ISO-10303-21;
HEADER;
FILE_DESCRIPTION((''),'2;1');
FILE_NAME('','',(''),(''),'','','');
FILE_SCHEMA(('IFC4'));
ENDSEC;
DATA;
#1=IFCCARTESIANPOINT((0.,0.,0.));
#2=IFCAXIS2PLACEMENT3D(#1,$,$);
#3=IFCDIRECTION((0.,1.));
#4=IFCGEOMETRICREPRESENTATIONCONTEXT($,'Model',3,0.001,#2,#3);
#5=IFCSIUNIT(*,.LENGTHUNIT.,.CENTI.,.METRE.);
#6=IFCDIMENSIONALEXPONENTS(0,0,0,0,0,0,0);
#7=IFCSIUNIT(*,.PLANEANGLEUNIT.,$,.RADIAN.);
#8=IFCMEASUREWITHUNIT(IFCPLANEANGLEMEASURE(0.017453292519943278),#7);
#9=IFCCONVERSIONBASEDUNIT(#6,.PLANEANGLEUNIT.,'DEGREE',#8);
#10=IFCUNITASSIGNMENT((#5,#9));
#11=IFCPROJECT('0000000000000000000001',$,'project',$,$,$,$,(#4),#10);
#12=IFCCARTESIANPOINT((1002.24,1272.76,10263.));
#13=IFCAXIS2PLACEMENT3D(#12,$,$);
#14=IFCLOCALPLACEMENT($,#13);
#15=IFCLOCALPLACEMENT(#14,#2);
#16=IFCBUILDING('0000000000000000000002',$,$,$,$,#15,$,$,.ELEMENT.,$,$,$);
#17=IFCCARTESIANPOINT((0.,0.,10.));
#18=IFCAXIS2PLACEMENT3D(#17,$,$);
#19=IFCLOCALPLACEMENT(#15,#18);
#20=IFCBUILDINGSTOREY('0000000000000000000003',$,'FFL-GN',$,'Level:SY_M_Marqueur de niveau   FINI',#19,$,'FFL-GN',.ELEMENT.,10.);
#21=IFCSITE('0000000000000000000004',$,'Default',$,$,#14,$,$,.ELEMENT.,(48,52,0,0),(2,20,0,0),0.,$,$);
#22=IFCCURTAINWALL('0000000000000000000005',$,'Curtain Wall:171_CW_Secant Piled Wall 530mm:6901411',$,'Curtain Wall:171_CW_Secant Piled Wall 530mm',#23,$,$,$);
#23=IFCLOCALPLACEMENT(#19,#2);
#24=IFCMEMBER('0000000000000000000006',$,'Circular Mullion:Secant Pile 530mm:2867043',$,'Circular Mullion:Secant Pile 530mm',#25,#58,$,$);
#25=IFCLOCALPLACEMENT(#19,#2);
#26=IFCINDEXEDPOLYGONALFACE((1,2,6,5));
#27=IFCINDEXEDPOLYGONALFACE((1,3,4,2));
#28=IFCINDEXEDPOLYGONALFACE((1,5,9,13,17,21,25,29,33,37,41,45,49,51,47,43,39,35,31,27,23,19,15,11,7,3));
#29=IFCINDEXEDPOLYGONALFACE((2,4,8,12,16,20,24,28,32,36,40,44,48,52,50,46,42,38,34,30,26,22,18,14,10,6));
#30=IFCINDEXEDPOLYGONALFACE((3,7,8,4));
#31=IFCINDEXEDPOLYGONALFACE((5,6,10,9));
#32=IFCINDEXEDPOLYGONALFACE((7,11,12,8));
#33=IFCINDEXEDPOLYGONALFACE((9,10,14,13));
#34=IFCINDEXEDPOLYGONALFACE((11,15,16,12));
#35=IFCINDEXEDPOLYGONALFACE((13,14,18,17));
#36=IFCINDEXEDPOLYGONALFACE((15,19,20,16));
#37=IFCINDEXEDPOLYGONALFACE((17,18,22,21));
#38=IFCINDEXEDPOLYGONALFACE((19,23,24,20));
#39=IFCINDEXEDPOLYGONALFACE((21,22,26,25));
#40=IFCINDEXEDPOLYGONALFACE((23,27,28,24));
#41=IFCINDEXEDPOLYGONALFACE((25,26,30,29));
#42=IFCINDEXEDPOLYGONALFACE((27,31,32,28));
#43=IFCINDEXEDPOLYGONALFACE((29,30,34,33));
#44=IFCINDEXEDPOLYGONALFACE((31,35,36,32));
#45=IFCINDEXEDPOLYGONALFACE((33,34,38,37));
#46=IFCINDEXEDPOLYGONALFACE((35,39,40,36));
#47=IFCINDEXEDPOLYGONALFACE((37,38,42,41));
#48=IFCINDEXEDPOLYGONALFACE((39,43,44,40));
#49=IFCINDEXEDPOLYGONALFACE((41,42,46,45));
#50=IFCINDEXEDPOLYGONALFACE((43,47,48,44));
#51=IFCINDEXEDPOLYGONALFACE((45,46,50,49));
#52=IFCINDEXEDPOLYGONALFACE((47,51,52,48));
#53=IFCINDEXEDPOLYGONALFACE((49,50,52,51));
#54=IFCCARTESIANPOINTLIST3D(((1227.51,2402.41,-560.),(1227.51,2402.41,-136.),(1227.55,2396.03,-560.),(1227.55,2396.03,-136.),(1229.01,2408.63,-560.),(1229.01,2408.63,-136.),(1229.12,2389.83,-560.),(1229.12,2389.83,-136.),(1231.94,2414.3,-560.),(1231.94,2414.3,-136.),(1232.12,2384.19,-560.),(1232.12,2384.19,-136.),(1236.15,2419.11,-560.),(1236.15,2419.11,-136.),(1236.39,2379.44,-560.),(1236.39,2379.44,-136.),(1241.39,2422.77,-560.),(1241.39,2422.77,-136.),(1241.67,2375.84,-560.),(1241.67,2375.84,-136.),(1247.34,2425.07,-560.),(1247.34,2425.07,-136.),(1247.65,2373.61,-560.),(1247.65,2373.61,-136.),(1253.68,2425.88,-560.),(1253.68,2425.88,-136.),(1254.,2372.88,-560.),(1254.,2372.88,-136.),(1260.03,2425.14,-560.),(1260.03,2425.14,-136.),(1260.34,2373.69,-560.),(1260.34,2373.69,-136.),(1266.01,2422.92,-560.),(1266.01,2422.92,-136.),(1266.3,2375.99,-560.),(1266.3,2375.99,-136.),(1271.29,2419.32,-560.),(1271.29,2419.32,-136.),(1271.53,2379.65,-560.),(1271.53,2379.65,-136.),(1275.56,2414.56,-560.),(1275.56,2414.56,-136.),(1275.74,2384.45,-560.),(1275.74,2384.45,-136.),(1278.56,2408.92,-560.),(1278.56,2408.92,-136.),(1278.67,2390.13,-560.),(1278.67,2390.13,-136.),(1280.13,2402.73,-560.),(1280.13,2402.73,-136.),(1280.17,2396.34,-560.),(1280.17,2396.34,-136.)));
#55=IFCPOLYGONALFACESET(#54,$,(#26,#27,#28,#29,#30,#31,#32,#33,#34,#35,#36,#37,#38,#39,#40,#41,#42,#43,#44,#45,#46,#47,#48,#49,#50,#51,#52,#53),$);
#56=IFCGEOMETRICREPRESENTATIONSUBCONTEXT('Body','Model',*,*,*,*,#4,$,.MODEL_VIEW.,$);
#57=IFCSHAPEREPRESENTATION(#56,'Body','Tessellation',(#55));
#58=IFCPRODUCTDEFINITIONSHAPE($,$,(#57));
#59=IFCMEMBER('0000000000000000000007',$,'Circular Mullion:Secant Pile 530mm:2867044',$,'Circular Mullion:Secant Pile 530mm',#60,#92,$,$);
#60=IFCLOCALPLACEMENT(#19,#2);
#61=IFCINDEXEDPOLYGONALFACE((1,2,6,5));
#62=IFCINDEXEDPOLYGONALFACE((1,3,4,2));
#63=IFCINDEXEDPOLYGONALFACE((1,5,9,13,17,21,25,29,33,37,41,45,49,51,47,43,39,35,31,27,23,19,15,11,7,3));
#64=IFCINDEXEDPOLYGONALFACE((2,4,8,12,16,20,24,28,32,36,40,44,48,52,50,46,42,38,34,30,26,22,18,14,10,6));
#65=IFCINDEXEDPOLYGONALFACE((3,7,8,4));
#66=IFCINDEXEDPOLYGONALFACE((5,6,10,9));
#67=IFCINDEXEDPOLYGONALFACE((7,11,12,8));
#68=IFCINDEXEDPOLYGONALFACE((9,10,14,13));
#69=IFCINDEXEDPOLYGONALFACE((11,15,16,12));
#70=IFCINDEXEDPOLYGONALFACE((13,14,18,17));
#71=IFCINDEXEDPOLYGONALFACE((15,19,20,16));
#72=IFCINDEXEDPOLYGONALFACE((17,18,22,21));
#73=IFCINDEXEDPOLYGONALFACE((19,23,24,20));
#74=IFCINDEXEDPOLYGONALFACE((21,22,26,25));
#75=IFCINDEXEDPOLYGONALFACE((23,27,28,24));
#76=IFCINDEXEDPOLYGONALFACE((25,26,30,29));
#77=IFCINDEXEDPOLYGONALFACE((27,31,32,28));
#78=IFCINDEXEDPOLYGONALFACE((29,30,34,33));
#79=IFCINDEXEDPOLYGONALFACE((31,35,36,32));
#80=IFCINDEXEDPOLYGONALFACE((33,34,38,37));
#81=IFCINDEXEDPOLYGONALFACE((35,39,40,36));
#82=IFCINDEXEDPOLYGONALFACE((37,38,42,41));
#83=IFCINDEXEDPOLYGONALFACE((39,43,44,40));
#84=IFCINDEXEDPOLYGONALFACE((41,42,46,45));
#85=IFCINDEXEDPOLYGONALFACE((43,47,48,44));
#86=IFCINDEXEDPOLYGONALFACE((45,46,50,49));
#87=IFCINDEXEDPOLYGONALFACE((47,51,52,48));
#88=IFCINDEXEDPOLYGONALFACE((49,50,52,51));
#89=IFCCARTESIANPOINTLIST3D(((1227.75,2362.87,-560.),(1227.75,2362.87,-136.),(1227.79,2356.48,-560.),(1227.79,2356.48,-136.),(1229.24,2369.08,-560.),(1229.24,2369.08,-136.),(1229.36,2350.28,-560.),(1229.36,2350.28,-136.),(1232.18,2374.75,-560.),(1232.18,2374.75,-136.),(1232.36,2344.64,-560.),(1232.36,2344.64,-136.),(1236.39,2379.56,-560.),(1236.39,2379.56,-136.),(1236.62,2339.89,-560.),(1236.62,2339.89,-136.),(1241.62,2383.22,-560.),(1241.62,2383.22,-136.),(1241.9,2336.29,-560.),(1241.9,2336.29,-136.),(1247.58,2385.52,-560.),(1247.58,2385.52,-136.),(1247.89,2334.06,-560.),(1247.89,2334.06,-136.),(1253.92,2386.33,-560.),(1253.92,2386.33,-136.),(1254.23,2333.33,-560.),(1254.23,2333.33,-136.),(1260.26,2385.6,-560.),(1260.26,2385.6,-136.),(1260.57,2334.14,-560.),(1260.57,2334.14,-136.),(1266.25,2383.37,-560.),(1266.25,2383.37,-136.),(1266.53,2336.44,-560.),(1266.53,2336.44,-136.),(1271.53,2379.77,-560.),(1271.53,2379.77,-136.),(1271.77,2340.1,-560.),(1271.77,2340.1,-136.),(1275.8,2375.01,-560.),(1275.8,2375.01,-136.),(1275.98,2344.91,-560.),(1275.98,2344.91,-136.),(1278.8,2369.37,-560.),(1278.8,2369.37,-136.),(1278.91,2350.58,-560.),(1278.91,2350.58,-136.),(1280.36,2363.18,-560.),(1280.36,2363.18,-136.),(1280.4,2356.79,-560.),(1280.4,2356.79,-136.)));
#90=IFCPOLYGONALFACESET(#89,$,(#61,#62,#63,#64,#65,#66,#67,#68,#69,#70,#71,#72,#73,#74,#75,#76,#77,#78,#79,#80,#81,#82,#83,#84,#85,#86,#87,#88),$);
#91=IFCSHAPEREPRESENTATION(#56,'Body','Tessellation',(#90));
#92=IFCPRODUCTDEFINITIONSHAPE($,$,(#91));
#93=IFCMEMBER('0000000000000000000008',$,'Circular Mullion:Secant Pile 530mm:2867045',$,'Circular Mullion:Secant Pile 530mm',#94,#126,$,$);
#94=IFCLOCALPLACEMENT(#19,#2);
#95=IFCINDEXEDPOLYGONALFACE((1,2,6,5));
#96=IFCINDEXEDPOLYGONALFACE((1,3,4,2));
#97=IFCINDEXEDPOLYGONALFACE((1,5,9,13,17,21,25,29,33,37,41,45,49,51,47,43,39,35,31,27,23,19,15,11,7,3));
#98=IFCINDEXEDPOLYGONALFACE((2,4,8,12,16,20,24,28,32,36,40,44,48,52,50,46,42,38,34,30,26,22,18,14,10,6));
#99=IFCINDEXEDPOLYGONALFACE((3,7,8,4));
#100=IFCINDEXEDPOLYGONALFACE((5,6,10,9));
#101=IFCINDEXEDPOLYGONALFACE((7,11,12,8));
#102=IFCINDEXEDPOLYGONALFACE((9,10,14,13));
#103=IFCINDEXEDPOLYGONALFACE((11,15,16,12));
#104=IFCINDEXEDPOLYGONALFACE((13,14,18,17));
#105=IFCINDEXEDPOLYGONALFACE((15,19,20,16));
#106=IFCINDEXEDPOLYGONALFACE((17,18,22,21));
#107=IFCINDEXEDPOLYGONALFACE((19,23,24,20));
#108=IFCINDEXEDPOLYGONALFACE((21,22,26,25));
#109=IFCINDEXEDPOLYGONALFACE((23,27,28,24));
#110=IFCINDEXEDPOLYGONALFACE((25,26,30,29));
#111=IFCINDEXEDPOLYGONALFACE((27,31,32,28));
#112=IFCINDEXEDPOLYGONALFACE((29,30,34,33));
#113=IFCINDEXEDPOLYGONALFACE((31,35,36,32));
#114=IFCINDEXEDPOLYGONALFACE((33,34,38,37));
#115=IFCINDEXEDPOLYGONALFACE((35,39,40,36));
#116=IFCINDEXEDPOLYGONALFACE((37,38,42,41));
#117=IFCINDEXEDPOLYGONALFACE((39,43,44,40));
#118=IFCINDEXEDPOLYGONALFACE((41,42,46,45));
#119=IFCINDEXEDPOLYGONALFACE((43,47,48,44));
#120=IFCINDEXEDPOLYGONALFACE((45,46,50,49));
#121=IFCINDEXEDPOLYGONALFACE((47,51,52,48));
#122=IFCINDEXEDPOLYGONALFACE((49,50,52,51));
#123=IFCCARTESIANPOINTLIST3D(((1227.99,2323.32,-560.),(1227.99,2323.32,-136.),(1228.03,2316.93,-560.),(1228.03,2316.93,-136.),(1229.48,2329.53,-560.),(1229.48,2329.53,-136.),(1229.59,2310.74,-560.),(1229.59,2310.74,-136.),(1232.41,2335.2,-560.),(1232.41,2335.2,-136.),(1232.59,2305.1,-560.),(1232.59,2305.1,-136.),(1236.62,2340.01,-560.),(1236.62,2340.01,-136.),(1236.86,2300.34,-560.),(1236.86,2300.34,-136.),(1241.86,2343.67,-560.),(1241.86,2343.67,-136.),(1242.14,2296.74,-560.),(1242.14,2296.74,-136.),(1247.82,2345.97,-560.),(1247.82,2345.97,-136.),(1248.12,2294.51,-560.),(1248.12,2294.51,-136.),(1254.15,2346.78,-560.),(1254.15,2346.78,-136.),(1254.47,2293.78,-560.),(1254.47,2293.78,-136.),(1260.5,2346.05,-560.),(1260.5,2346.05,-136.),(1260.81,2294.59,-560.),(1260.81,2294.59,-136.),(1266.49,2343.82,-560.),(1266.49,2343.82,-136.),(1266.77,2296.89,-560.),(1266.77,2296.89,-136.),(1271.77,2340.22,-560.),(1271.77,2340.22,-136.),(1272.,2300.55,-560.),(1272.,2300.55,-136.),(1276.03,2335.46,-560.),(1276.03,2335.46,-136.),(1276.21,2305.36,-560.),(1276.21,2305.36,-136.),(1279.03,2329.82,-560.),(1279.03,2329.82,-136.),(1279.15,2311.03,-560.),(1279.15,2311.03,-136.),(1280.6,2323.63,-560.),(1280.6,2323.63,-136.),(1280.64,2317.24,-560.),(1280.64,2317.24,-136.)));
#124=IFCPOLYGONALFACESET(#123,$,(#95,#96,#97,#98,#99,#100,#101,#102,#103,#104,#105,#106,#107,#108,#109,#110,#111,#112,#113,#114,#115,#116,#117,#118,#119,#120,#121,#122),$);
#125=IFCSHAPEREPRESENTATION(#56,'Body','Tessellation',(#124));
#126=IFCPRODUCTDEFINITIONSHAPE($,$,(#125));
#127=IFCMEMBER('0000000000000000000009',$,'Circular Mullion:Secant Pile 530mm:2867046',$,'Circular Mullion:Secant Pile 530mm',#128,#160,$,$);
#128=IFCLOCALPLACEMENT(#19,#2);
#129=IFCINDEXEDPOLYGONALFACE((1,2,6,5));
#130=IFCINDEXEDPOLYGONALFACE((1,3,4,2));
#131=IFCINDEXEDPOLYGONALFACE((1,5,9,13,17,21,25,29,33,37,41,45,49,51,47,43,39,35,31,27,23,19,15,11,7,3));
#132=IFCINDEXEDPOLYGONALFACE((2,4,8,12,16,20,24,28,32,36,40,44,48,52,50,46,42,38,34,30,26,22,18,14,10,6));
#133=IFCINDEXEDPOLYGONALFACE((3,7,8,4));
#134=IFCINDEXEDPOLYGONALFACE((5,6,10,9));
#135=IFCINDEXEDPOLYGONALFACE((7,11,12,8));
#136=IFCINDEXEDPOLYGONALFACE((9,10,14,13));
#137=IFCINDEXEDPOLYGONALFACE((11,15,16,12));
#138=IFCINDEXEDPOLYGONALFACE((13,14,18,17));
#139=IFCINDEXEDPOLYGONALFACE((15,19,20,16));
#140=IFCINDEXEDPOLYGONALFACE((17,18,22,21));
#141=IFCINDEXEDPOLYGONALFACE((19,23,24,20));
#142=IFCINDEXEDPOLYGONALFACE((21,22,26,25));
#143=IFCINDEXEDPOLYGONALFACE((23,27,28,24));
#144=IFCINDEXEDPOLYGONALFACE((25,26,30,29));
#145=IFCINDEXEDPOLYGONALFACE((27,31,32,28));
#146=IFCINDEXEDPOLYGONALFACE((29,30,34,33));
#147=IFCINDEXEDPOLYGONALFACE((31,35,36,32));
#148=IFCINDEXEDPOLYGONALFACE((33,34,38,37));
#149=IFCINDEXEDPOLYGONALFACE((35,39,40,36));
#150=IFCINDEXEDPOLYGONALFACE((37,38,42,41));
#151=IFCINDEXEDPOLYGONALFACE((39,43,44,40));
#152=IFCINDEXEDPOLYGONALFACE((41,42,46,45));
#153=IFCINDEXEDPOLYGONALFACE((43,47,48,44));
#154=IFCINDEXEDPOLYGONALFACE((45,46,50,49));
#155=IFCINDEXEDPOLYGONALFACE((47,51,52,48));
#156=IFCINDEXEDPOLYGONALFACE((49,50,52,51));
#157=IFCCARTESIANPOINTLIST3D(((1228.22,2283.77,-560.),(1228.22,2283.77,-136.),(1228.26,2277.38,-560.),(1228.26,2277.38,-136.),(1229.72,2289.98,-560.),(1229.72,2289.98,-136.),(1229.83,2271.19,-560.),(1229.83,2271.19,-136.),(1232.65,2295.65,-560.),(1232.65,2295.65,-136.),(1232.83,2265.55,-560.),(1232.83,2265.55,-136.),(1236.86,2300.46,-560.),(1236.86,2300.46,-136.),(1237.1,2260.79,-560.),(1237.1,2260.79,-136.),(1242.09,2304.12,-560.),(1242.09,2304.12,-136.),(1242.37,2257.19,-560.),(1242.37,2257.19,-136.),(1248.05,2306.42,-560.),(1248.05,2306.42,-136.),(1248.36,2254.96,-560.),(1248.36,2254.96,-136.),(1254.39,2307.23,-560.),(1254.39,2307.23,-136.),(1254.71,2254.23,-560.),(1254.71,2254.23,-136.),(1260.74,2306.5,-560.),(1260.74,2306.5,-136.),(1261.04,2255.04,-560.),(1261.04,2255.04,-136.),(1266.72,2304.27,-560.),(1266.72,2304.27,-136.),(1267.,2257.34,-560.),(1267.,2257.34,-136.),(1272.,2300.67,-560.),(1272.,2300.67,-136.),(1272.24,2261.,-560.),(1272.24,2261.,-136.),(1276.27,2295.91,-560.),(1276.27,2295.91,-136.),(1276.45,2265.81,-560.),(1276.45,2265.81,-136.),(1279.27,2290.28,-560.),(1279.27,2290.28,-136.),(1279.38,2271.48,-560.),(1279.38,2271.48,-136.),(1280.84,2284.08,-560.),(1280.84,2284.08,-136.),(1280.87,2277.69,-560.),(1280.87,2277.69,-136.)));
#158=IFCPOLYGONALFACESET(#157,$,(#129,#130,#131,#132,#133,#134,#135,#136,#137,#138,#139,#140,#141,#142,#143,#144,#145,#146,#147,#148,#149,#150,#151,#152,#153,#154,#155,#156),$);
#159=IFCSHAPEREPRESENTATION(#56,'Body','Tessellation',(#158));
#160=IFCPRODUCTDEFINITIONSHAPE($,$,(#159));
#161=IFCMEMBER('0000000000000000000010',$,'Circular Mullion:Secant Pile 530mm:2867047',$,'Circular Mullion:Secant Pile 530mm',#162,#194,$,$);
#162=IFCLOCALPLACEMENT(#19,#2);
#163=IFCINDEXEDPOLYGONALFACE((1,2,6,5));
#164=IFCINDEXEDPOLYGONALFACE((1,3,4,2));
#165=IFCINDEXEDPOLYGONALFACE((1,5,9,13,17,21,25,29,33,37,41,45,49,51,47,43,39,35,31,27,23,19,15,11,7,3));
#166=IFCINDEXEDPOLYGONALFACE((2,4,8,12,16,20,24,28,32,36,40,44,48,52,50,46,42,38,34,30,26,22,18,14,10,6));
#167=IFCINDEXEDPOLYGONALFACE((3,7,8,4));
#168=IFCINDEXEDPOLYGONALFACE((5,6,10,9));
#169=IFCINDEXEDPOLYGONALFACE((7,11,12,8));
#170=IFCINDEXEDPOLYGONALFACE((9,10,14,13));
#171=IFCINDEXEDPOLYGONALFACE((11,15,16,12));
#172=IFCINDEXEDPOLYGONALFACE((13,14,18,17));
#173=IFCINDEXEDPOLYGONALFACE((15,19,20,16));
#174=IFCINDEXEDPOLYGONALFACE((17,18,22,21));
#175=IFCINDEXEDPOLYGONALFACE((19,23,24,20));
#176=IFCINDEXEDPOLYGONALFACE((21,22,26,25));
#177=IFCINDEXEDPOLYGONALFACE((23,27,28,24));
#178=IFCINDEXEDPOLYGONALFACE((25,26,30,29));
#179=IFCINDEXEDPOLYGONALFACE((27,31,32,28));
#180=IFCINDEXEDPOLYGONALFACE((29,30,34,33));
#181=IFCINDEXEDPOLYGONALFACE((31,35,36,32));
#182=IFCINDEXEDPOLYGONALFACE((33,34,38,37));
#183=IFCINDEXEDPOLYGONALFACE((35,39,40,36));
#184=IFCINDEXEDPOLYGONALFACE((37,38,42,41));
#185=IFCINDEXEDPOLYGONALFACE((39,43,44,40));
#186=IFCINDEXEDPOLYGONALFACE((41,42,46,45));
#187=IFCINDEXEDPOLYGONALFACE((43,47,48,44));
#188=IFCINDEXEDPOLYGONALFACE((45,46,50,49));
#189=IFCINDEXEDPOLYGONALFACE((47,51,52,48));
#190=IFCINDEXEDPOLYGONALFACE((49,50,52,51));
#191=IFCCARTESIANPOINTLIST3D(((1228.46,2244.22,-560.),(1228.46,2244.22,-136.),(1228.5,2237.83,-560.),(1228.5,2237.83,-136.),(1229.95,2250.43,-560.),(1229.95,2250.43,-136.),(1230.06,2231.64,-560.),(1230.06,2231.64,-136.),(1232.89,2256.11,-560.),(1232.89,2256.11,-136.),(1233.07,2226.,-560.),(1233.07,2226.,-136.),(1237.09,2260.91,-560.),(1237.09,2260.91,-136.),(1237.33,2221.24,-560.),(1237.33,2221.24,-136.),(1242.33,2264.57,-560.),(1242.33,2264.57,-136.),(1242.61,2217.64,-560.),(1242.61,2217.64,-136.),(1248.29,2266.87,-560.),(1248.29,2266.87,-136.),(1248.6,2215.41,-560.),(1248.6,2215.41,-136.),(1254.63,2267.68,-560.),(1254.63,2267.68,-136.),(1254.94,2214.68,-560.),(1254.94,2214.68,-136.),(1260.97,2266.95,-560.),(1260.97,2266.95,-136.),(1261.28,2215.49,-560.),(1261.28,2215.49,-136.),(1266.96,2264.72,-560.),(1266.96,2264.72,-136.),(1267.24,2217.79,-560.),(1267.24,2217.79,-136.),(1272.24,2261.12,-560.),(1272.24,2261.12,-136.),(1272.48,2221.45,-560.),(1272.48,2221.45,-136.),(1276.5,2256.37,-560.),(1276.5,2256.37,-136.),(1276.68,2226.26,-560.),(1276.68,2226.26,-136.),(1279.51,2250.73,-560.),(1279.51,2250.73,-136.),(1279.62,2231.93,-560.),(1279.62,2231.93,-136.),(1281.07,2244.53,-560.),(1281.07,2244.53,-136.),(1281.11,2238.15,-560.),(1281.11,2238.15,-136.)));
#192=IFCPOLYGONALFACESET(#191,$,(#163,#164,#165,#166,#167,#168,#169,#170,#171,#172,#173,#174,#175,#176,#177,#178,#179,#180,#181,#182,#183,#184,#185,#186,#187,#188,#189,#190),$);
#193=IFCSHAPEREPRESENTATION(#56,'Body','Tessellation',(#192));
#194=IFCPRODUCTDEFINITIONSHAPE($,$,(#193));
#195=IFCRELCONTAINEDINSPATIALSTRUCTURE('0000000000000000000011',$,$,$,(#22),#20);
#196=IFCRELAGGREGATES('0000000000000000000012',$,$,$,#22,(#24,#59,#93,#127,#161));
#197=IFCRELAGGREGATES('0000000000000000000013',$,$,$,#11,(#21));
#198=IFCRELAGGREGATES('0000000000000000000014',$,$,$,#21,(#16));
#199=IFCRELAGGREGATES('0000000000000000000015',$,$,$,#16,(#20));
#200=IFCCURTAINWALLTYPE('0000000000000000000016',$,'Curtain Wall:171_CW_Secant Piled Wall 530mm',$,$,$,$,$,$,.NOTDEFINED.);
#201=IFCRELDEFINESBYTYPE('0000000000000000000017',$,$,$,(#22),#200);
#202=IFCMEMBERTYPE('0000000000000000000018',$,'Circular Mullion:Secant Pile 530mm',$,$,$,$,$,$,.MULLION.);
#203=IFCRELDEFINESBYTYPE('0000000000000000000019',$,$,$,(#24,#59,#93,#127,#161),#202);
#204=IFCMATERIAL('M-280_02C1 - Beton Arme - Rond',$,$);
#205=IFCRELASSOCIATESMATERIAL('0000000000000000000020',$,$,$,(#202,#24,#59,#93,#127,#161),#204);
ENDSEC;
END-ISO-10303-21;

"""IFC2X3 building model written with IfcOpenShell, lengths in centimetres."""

from ifc_helpers import new_model, entity, si_unit, converted_unit, direction, frame, frame_2d, origin, place, context, subcontext, project, spatial, circle, extrude, source, transform, mapped, material, type_object, type_shapes, element, aggregate, save


model = new_model("IFC2X3")

# Units and contexts
model_context = context("Model", 3, precision=0.001, world=origin(), true_north=direction((0.0, 1.0)))
body_context = subcontext(model_context, "Body", "Model", "MODEL_VIEW")
ifc_project = project(units=[si_unit("LENGTHUNIT", "METRE", prefix="CENTI"), converted_unit("PLANEANGLEUNIT", "DEGREE", entity("IfcPlaneAngleMeasure", 0.017453292519943278), si_unit("PLANEANGLEUNIT", "RADIAN"), dimensions=[0, 0, 0, 0, 0, 0, 0])], contexts=[model_context])

# Site, building, storey
site_placement = place(None, frame((1002.24, 1272.76, 10263.0)))
site = spatial("IfcSite", under=ifc_project, at=site_placement, Name="Default", CompositionType="ELEMENT", RefLatitude=(48, 52, 0, 0), RefLongitude=(2, 20, 0, 0), RefElevation=0.0)
building_placement = place(site_placement, origin())
building = spatial("IfcBuilding", under=site, at=building_placement, CompositionType="ELEMENT")
storey_placement = place(building_placement, frame((0.0, 0.0, 10.0)))
storey = spatial("IfcBuildingStorey", under=building, at=storey_placement, Name="FFL-GN", ObjectType="Level:SY_M_Marqueur de niveau   FINI", LongName="FFL-GN", CompositionType="ELEMENT", Elevation=10.0)

# Curtain wall, members
curtain_wall_type = type_object("IfcCurtainWallType", Name="Curtain Wall:171_CW_Secant Piled Wall 530mm", PredefinedType="NOTDEFINED")
ifc_material_1 = material(Name="M-280_02C1 - Beton Arme - Rond")
member_type = type_object("IfcMemberType", Name="Circular Mullion:Secant Pile 530mm", PredefinedType="MULLION", material=ifc_material_1)
shared_shape = source(origin(), body_context, "Body", "SweptSolid", [
    extrude(circle(Radius=26.5, at=frame_2d((0.0, 0.0), x_axis=(1.0, 0.0))), frame((0.0, 0.0, -424.0)), (0.0, 0.0, 1.0), 424.0),
])
type_shapes(member_type, [shared_shape])
curtain_wall_1_placement = place(storey_placement, frame((0.0, 0.0, -10.0)))
curtain_wall_1 = element("IfcCurtainWall", 1, at=curtain_wall_1_placement, inside=storey, type_object=curtain_wall_type, Name="Curtain Wall:171_CW_Secant Piled Wall 530mm:6901411", ObjectType="Curtain Wall:171_CW_Secant Piled Wall 530mm")
member_1_placement = place(curtain_wall_1_placement, frame((1253.84, 2399.38, -550.0), z_axis=(0.0, 0.0, -1.0), x_axis=(0.005975, -0.999982, 0.0)))
member_1 = element("IfcMember", 2, at=member_1_placement, type_object=member_type, material=ifc_material_1, Name="Circular Mullion:Secant Pile 530mm:2867043", ObjectType="Circular Mullion:Secant Pile 530mm", context=body_context, shape_type="MappedRepresentation", body=[
    mapped(shared_shape, transform((0.0, 0.0, 0.0), scale=1.0)),
])
member_2_placement = place(curtain_wall_1_placement, frame((1254.08, 2359.83, -550.0), z_axis=(0.0, 0.0, -1.0), x_axis=(0.005975, -0.999982, 0.0)))
member_2 = element("IfcMember", 3, at=member_2_placement, type_object=member_type, material=ifc_material_1, Name="Circular Mullion:Secant Pile 530mm:2867044", ObjectType="Circular Mullion:Secant Pile 530mm", context=body_context, shape_type="MappedRepresentation", body=[
    mapped(shared_shape, transform((0.0, 0.0, 0.0), scale=1.0)),
])
member_3_placement = place(curtain_wall_1_placement, frame((1254.31, 2320.28, -550.0), z_axis=(0.0, 0.0, -1.0), x_axis=(0.005975, -0.999982, 0.0)))
member_3 = element("IfcMember", 4, at=member_3_placement, type_object=member_type, material=ifc_material_1, Name="Circular Mullion:Secant Pile 530mm:2867045", ObjectType="Circular Mullion:Secant Pile 530mm", context=body_context, shape_type="MappedRepresentation", body=[
    mapped(shared_shape, transform((0.0, 0.0, 0.0), scale=1.0)),
])
member_4_placement = place(curtain_wall_1_placement, frame((1254.55, 2280.73, -550.0), z_axis=(0.0, 0.0, -1.0), x_axis=(0.005975, -0.999982, 0.0)))
member_4 = element("IfcMember", 5, at=member_4_placement, type_object=member_type, material=ifc_material_1, Name="Circular Mullion:Secant Pile 530mm:2867046", ObjectType="Circular Mullion:Secant Pile 530mm", context=body_context, shape_type="MappedRepresentation", body=[
    mapped(shared_shape, transform((0.0, 0.0, 0.0), scale=1.0)),
])
member_5_placement = place(curtain_wall_1_placement, frame((1254.79, 2241.18, -550.0), z_axis=(0.0, 0.0, -1.0), x_axis=(0.005975, -0.999982, 0.0)))
member_5 = element("IfcMember", 6, at=member_5_placement, type_object=member_type, material=ifc_material_1, Name="Circular Mullion:Secant Pile 530mm:2867047", ObjectType="Circular Mullion:Secant Pile 530mm", context=body_context, shape_type="MappedRepresentation", body=[
    mapped(shared_shape, transform((0.0, 0.0, 0.0), scale=1.0)),
])
aggregate(curtain_wall_1, [member_1, member_2, member_3, member_4, member_5])

save(model, "model.ifc")
